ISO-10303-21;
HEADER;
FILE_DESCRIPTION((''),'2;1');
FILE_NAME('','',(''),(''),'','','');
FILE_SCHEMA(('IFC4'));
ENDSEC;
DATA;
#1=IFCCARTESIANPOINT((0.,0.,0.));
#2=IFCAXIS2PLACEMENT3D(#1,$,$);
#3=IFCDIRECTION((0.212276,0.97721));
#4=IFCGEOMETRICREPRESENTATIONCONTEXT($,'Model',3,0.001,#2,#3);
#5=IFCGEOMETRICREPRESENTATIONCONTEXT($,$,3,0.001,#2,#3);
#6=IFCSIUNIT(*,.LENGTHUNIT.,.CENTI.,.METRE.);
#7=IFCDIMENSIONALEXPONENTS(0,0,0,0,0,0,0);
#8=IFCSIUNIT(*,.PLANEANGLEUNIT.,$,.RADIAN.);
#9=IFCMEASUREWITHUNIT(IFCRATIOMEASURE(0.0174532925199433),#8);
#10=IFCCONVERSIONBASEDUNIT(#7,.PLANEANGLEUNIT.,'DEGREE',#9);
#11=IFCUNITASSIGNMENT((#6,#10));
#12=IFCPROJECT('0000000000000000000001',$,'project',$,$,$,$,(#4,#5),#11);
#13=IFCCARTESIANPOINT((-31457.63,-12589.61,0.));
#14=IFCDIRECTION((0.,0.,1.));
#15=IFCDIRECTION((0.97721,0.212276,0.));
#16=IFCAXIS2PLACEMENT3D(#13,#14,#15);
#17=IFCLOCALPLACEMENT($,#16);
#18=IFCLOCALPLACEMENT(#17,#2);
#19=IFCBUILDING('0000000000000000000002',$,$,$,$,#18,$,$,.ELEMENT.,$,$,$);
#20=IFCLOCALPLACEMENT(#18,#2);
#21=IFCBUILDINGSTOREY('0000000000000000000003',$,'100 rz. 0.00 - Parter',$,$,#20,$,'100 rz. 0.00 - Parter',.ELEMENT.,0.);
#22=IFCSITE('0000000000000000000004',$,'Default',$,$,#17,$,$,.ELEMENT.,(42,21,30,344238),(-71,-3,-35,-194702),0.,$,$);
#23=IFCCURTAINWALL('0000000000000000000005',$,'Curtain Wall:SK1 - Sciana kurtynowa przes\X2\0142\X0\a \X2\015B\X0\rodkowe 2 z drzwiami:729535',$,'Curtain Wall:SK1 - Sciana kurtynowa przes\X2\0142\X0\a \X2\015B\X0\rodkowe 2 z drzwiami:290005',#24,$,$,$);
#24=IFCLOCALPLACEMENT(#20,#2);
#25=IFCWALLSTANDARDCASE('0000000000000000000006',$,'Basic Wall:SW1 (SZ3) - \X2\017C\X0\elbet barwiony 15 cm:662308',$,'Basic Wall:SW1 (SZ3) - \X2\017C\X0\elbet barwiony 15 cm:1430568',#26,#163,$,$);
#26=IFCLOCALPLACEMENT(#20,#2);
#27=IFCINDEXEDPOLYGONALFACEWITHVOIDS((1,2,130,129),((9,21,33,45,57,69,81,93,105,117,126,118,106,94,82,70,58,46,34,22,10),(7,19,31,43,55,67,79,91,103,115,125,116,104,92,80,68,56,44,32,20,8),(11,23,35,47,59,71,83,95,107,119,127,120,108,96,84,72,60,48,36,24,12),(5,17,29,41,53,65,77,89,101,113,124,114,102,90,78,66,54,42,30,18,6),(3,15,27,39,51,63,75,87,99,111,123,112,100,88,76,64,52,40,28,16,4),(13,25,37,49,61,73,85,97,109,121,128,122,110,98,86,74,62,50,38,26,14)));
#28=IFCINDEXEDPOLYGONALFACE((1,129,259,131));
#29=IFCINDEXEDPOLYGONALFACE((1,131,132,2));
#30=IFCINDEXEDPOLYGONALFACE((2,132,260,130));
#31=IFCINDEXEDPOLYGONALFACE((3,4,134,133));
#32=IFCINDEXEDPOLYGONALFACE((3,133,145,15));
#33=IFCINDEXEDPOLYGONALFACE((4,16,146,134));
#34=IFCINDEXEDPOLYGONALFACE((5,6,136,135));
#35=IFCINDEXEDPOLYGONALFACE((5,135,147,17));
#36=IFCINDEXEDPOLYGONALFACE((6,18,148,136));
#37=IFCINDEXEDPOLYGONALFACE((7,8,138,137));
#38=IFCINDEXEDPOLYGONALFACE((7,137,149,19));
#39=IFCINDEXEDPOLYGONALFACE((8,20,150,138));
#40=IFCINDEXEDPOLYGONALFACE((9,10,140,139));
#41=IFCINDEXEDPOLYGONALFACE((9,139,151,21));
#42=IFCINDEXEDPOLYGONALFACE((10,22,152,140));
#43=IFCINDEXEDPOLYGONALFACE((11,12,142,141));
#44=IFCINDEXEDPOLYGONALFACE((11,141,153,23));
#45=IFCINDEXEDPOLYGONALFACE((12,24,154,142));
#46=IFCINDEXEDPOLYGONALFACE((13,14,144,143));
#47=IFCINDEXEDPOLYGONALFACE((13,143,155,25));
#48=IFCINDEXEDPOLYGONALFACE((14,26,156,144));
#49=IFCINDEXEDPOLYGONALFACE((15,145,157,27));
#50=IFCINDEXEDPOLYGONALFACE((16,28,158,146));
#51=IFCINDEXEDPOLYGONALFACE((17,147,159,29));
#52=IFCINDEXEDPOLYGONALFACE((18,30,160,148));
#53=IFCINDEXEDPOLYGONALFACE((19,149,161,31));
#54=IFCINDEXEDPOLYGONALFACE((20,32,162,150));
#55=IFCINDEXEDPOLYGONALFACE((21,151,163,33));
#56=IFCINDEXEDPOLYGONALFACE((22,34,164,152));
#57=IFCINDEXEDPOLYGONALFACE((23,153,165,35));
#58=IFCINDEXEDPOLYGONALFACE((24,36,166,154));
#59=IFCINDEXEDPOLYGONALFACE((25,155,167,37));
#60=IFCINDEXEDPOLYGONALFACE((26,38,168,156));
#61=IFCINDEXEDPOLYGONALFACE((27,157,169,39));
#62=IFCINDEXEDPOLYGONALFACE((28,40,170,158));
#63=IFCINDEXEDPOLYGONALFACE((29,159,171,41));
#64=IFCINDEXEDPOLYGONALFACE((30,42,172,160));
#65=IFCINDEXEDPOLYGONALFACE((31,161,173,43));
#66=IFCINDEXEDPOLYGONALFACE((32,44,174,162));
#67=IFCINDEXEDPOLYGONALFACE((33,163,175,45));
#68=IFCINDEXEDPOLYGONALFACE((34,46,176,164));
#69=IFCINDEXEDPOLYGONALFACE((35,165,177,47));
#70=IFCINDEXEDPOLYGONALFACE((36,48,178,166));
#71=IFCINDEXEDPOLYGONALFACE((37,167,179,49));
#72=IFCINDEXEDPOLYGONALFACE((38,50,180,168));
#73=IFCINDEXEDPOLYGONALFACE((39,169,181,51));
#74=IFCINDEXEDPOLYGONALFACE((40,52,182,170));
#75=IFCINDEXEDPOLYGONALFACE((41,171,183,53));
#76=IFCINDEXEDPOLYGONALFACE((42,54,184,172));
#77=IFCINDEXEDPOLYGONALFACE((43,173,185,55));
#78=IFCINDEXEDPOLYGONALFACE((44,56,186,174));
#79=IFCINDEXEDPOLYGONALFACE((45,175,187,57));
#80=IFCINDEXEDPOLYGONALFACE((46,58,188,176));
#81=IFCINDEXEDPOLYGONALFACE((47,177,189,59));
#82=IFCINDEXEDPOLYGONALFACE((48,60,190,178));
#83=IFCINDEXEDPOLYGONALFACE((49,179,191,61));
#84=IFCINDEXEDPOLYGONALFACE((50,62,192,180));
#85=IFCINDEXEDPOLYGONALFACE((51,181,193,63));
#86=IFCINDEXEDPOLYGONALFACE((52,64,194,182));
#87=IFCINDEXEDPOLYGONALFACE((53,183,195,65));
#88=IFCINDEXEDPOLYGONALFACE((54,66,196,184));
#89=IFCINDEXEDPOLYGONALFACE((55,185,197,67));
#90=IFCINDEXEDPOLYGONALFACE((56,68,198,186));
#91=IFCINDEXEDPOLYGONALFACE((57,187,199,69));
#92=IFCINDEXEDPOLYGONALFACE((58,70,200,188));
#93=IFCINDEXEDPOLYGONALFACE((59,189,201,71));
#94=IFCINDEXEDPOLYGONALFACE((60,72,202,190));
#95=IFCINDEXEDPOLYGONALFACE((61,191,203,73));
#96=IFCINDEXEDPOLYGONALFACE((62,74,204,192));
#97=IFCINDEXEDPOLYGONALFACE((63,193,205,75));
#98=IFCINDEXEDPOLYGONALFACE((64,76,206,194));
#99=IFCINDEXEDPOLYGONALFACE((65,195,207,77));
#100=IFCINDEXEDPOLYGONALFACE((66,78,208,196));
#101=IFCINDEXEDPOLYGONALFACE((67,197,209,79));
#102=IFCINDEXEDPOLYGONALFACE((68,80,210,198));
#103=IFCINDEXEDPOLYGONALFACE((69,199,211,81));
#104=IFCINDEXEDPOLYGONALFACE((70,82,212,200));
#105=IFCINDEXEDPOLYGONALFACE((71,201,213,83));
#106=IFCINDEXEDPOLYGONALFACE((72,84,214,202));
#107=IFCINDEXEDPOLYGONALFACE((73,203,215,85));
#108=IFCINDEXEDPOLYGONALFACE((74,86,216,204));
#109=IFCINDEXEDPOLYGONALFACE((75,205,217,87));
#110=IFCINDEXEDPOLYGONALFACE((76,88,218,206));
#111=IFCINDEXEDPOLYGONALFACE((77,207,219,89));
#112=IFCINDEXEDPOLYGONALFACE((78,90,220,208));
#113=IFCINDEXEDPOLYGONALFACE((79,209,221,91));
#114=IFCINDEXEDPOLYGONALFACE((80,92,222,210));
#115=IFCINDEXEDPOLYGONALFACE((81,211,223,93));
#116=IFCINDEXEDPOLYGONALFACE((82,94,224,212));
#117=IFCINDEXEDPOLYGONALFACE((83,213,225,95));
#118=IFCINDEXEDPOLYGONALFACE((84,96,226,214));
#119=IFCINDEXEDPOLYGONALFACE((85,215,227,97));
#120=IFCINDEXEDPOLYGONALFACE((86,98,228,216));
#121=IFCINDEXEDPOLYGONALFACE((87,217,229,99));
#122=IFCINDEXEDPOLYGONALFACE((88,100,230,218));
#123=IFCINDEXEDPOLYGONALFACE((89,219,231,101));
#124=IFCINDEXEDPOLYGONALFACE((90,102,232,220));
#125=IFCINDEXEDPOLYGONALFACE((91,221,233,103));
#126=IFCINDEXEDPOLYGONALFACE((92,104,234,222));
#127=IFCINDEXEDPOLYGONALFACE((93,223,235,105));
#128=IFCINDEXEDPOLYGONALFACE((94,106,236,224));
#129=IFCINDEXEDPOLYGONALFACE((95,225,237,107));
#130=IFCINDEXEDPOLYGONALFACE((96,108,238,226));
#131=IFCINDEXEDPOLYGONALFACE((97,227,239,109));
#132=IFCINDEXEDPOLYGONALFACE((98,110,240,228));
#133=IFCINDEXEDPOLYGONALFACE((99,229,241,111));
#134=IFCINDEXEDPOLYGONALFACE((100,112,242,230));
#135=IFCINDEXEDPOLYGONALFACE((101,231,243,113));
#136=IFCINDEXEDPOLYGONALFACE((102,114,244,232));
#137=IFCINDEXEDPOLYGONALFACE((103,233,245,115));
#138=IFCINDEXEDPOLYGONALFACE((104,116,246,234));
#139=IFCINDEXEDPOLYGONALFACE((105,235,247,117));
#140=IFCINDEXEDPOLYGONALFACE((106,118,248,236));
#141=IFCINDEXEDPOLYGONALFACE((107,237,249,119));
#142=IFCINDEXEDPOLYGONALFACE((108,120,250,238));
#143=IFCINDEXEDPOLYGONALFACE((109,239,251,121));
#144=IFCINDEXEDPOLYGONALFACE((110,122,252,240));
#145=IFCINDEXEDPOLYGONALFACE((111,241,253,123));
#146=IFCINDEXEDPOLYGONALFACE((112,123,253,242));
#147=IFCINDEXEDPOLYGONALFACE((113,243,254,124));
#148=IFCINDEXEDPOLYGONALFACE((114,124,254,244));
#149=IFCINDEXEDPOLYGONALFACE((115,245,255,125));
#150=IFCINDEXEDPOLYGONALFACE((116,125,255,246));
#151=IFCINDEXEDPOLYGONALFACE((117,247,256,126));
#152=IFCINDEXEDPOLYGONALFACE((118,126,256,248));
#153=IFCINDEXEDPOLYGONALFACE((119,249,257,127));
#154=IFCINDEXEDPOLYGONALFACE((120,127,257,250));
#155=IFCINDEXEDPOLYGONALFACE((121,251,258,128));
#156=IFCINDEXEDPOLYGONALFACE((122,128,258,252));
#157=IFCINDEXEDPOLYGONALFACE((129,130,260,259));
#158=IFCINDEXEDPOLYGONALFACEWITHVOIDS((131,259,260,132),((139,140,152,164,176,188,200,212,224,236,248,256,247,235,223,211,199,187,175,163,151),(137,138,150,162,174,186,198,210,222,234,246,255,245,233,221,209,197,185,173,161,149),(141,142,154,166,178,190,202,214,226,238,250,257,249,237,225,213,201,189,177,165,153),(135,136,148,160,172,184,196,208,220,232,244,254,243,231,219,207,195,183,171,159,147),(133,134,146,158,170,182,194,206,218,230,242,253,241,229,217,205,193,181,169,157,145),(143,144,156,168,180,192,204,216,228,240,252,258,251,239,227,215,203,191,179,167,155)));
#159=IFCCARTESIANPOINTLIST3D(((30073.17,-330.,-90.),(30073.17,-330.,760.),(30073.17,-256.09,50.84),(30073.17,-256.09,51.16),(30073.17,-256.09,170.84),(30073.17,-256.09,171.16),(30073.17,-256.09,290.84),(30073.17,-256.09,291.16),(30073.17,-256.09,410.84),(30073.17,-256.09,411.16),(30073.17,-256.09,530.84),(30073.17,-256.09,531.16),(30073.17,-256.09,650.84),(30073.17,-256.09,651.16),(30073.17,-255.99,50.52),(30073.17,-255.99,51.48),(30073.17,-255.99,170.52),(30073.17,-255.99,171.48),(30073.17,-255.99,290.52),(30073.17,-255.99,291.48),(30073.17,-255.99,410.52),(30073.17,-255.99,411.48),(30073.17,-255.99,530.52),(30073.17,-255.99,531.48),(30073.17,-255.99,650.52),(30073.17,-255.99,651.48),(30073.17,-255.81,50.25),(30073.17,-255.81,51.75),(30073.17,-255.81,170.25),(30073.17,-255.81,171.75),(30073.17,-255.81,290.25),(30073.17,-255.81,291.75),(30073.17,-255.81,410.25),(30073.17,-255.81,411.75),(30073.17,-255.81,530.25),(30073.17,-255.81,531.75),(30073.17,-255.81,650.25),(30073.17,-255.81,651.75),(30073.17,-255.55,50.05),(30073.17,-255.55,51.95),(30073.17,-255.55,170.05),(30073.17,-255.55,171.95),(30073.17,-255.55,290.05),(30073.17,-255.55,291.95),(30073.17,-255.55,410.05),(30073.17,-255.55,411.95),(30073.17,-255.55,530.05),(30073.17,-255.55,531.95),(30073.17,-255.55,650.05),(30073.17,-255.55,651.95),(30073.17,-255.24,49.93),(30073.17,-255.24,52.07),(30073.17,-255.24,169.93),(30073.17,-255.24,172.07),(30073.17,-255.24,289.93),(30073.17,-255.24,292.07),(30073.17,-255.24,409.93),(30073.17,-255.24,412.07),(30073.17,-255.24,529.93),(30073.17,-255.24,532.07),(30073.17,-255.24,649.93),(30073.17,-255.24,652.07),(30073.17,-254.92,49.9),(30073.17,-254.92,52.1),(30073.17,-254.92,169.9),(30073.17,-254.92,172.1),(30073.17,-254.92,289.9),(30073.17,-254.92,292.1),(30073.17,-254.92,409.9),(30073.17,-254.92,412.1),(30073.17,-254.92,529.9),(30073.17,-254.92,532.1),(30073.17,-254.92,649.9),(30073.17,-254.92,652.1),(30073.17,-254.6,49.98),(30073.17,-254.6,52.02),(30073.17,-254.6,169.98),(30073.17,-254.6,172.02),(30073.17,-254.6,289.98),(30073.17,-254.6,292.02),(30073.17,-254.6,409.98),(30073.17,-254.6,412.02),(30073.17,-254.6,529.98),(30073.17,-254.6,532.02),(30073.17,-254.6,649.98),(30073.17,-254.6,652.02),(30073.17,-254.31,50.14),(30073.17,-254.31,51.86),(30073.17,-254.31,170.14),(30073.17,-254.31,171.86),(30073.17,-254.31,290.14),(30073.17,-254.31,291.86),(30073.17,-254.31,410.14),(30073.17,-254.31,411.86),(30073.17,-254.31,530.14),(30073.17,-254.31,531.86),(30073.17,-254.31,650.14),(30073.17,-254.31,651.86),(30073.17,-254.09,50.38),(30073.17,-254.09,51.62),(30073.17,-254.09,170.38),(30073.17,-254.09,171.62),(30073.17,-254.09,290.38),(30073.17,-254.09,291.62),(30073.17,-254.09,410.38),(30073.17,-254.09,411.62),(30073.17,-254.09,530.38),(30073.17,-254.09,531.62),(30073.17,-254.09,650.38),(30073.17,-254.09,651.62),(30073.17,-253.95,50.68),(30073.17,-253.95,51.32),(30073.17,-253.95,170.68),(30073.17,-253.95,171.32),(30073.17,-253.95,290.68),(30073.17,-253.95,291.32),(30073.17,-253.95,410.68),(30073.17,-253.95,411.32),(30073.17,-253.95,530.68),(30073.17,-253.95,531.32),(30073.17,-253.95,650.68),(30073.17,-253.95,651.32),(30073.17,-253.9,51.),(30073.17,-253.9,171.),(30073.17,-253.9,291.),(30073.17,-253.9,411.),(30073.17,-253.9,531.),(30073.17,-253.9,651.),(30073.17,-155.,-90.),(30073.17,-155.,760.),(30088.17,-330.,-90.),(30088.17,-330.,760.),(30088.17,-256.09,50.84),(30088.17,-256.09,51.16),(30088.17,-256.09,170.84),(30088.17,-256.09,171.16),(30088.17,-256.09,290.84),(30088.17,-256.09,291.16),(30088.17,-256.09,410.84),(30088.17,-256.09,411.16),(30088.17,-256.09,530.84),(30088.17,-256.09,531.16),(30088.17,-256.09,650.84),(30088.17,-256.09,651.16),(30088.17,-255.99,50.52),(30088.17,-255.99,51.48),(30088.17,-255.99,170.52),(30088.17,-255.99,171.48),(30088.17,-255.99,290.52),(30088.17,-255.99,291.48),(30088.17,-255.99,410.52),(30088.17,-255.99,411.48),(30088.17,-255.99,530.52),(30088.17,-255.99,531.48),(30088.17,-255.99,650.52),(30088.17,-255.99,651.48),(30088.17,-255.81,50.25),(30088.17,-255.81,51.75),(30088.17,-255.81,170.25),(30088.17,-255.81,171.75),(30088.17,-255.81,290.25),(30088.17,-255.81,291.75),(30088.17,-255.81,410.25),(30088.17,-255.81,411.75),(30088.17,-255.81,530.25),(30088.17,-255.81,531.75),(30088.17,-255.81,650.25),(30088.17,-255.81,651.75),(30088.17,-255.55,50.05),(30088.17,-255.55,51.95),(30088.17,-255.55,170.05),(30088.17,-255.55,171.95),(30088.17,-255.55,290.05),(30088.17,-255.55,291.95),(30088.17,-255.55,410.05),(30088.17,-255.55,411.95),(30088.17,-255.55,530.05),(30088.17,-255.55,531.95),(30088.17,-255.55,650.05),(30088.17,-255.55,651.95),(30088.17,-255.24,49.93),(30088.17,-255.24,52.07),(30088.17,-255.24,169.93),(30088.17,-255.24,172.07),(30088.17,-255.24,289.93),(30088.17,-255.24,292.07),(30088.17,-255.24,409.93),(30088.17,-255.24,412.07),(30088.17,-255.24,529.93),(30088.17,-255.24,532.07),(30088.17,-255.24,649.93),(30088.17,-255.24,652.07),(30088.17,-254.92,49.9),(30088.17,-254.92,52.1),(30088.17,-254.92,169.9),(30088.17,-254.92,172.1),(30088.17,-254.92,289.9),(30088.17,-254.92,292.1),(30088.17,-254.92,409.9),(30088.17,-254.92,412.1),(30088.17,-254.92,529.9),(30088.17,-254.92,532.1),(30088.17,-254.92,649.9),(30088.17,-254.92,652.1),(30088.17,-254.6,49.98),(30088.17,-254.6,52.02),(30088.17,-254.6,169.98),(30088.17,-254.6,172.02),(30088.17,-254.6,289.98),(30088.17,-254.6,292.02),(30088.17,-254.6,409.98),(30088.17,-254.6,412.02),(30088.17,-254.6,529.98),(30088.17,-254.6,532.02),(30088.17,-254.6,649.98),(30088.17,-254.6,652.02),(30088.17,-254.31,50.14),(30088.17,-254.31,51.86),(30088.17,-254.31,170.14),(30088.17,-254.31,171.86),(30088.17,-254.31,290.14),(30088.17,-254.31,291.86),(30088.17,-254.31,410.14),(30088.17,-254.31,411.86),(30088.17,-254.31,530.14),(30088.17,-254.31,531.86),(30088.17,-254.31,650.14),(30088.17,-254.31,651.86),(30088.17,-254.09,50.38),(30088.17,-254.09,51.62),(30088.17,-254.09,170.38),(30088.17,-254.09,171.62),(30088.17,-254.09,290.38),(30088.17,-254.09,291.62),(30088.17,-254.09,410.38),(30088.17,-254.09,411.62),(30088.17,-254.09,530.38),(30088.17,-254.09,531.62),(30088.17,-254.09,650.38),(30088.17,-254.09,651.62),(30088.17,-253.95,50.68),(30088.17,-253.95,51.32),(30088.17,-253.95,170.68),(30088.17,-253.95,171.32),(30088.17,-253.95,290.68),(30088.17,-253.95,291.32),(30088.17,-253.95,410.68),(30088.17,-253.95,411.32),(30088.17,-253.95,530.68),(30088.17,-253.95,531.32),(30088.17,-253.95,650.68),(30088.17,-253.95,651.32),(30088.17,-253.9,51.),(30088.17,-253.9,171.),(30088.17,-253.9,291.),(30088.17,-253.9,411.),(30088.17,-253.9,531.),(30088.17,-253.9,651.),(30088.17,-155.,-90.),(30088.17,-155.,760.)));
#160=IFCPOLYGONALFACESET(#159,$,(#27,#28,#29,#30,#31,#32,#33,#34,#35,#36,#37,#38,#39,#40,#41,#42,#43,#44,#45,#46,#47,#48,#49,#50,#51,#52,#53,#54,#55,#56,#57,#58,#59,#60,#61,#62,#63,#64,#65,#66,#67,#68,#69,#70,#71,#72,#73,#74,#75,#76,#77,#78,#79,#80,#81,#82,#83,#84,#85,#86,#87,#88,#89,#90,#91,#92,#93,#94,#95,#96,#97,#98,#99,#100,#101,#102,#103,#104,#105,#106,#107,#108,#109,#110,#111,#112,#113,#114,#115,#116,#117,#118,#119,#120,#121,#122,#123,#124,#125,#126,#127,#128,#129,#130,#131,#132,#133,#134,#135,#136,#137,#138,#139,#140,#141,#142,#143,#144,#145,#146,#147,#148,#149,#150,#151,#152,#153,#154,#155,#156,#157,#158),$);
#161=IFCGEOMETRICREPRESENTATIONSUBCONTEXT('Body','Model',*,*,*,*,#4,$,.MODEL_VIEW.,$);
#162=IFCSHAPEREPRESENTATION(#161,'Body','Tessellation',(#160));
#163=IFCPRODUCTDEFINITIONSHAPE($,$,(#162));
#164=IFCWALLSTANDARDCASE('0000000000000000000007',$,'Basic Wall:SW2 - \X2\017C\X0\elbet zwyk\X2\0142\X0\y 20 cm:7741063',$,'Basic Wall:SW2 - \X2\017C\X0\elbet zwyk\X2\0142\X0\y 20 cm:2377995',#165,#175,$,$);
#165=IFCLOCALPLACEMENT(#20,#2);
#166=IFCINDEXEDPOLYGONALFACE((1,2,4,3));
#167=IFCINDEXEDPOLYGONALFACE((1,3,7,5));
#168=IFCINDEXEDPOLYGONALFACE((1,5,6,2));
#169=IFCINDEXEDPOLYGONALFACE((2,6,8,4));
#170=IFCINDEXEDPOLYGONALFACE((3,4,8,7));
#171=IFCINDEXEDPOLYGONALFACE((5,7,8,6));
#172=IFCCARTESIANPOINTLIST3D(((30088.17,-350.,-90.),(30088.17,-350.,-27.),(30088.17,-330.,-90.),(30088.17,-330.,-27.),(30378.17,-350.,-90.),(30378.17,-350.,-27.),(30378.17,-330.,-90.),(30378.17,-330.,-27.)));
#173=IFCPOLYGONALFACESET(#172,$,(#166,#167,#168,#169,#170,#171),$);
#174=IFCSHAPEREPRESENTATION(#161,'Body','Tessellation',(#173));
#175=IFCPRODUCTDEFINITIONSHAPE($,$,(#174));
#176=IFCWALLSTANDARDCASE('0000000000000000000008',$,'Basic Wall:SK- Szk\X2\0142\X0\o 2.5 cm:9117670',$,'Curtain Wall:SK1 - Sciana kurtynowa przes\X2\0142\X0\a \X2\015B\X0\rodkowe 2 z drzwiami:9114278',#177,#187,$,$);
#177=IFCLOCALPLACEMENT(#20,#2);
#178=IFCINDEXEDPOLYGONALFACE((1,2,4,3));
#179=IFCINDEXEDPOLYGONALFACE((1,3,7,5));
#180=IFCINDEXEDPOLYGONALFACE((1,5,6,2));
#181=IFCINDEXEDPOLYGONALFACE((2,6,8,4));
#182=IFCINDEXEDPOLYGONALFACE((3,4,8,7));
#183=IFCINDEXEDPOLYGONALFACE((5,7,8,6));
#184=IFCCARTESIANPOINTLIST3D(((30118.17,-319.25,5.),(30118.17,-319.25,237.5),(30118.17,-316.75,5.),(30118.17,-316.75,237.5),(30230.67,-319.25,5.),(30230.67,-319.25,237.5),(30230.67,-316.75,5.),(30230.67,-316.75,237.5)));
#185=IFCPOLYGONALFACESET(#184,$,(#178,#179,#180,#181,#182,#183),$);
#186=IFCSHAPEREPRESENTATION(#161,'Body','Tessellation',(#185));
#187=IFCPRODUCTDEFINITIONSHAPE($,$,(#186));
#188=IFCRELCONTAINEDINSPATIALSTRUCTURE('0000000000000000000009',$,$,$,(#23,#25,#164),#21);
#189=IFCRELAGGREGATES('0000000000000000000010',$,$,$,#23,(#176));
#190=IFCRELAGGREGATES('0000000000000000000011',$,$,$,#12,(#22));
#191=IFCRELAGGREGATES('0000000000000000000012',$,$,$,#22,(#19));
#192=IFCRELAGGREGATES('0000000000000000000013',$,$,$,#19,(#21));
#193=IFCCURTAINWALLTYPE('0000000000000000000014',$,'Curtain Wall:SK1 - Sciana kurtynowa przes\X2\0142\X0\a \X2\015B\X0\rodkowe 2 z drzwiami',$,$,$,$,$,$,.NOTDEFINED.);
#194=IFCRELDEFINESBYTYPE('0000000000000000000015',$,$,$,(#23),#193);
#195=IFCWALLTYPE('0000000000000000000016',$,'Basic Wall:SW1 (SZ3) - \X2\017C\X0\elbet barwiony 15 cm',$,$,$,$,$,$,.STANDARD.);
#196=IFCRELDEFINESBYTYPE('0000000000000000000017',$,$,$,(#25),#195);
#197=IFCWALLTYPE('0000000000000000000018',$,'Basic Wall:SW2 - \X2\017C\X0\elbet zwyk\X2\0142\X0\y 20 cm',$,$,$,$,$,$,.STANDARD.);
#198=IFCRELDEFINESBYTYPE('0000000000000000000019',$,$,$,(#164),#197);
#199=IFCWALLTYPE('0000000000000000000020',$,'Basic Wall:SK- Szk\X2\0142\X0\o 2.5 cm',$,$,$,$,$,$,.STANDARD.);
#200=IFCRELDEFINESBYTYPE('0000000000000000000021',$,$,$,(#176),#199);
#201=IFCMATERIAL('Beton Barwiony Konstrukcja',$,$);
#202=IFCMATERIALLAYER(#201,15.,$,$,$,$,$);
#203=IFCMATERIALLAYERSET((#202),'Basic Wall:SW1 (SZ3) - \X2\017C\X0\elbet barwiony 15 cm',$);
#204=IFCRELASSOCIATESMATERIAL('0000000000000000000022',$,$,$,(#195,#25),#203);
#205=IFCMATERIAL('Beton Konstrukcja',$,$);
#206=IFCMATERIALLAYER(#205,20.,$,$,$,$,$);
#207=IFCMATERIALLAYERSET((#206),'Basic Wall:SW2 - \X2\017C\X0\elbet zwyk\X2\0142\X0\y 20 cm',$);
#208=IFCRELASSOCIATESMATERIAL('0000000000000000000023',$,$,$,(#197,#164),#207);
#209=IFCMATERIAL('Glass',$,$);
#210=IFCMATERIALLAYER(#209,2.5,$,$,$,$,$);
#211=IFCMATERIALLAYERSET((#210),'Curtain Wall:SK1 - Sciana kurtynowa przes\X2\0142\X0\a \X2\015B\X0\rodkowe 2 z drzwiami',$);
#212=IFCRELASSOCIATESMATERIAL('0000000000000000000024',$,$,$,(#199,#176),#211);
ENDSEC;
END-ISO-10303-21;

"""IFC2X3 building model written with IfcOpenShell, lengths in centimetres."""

from ifc_helpers import new_model, entity, si_unit, converted_unit, direction, frame, frame_2d, origin, origin_2d_with_axis, place, context, subcontext, project, spatial, rectangle, circle, extrude, material, layer, layer_set, layer_usage, type_object, element, aggregate, save


model = new_model("IFC2X3")

# Units and contexts
model_context = context("Model", 3, precision=0.001, world=origin(), true_north=direction((0.212276, 0.97721)))
context_of_model = context(None, 3, precision=0.001, world=origin(), true_north=direction((0.212276, 0.97721)))
body_context = subcontext(model_context, "Body", "Model", "MODEL_VIEW")
ifc_project = project(units=[si_unit("LENGTHUNIT", "METRE", prefix="CENTI"), converted_unit("PLANEANGLEUNIT", "DEGREE", entity("IfcRatioMeasure", 0.0174532925199433), si_unit("PLANEANGLEUNIT", "RADIAN"), dimensions=[0, 0, 0, 0, 0, 0, 0])], contexts=[model_context, context_of_model])

# Site, building, storey
site_placement = place(None, frame((-31457.63, -12589.61, 0.0), z_axis=(0.0, 0.0, 1.0), x_axis=(0.97721, 0.212276, 0.0)))
site = spatial("IfcSite", under=ifc_project, at=site_placement, Name="Default", CompositionType="ELEMENT", RefLatitude=(42, 21, 30, 344238), RefLongitude=(-71, -3, -35, -194702), RefElevation=0.0)
building_placement = place(site_placement, origin())
building = spatial("IfcBuilding", under=site, at=building_placement, CompositionType="ELEMENT")
storey_placement = place(building_placement, origin())
storey = spatial("IfcBuildingStorey", under=building, at=storey_placement, Name="100 rz. 0.00 - Parter", LongName="100 rz. 0.00 - Parter", CompositionType="ELEMENT", Elevation=0.0)

# Curtain wall
curtain_wall_type = type_object("IfcCurtainWallType", Name="Curtain Wall:SK1 - Sciana kurtynowa przesła środkowe 2 z drzwiami", PredefinedType="NOTDEFINED")
curtain_wall_placement = place(storey_placement, origin())
curtain_wall = element("IfcCurtainWall", 1, at=curtain_wall_placement, inside=storey, type_object=curtain_wall_type, Name="Curtain Wall:SK1 - Sciana kurtynowa przesła środkowe 2 z drzwiami:729535", ObjectType="Curtain Wall:SK1 - Sciana kurtynowa przesła środkowe 2 z drzwiami:290005")

# Wall, opening
ifc_material_1 = material(Name="Beton Barwiony Konstrukcja")
ifc_layer_1 = layer(ifc_material_1, 15.0)
ifc_layer_set_1 = layer_set([ifc_layer_1], Name="Basic Wall:SW1 (SZ3) - żelbet barwiony 15 cm")
ifc_layer_usage_1 = layer_usage(ifc_layer_set_1, "AXIS2", "NEGATIVE", 7.5)
wall_type_1 = type_object("IfcWallType", Name="Basic Wall:SW1 (SZ3) - żelbet barwiony 15 cm", PredefinedType="STANDARD", material=ifc_layer_set_1)
wall_1_placement = place(storey_placement, frame((30080.67, -330.0, -90.0), z_axis=(0.0, 0.0, 1.0), x_axis=(0.0, 1.0, 0.0)))
wall_1 = element("IfcWallStandardCase", 2, at=wall_1_placement, inside=storey, type_object=wall_type_1, material=ifc_layer_usage_1, Name="Basic Wall:SW1 (SZ3) - żelbet barwiony 15 cm:662308", ObjectType="Basic Wall:SW1 (SZ3) - żelbet barwiony 15 cm:1430568", context=body_context, shape_type="SweptSolid", body=[
    extrude(rectangle(XDim=175.0, YDim=15.0, at=frame_2d((87.5, 0.0), x_axis=(-1.0, 0.0))), origin(), (0.0, 0.0, 1.0), 850.0),
])
opening_placement = place(wall_1_placement, frame((73.74, 7.5, 139.74)))
element("IfcOpeningElement", 3, at=opening_placement, cuts=wall_1, ObjectType="Opening", context=body_context, shape_type="SweptSolid", body=[
    extrude(circle(Radius=1.1, at=frame_2d((0.0, 0.0), x_axis=(1.0, 0.0))), frame((1.26, -15.0, 1.26), z_axis=(0.0, 1.0, 0.0), x_axis=(1.0, 0.0, 0.0)), (0.0, 0.0, 1.0), 15.0),
    extrude(circle(Radius=1.1, at=origin_2d_with_axis()), frame((1.26, -15.0, 601.26), z_axis=(0.0, 1.0, 0.0), x_axis=(1.0, 0.0, 0.0)), (0.0, 0.0, 1.0), 15.0),
    extrude(circle(Radius=1.1, at=origin_2d_with_axis()), frame((1.26, -15.0, 121.26), z_axis=(0.0, 1.0, 0.0), x_axis=(1.0, 0.0, 0.0)), (0.0, 0.0, 1.0), 15.0),
    extrude(circle(Radius=1.1, at=origin_2d_with_axis()), frame((1.26, -15.0, 241.26), z_axis=(0.0, 1.0, 0.0), x_axis=(1.0, 0.0, 0.0)), (0.0, 0.0, 1.0), 15.0),
    extrude(circle(Radius=1.1, at=origin_2d_with_axis()), frame((1.26, -15.0, 361.26), z_axis=(0.0, 1.0, 0.0), x_axis=(1.0, 0.0, 0.0)), (0.0, 0.0, 1.0), 15.0),
    extrude(circle(Radius=1.1, at=origin_2d_with_axis()), frame((1.26, -15.0, 481.26), z_axis=(0.0, 1.0, 0.0), x_axis=(1.0, 0.0, 0.0)), (0.0, 0.0, 1.0), 15.0),
])

# Walls
ifc_material_2 = material(Name="Beton Konstrukcja")
ifc_layer_2 = layer(ifc_material_2, 20.0)
ifc_layer_set_2 = layer_set([ifc_layer_2], Name="Basic Wall:SW2 - żelbet zwykły 20 cm")
ifc_layer_usage_2 = layer_usage(ifc_layer_set_2, "AXIS2", "NEGATIVE", 10.0)
wall_type_2 = type_object("IfcWallType", Name="Basic Wall:SW2 - żelbet zwykły 20 cm", PredefinedType="STANDARD", material=ifc_layer_set_2)
wall_2_placement = place(storey_placement, frame((30088.17, -340.0, -90.0)))
element("IfcWallStandardCase", 4, at=wall_2_placement, inside=storey, type_object=wall_type_2, material=ifc_layer_usage_2, Name="Basic Wall:SW2 - żelbet zwykły 20 cm:7741063", ObjectType="Basic Wall:SW2 - żelbet zwykły 20 cm:2377995", context=body_context, shape_type="SweptSolid", body=[
    extrude(rectangle(XDim=290.0, YDim=20.0, at=frame_2d((145.0, 0.0), x_axis=(-1.0, 0.0))), origin(), (0.0, 0.0, 1.0), 63.0),
])
ifc_material_3 = material(Name="Glass")
ifc_layer_3 = layer(ifc_material_3, 2.5)
ifc_layer_set_3 = layer_set([ifc_layer_3], Name="Curtain Wall:SK1 - Sciana kurtynowa przesła środkowe 2 z drzwiami")
ifc_layer_usage_3 = layer_usage(ifc_layer_set_3, "AXIS2", "NEGATIVE", 1.25)
wall_type_3 = type_object("IfcWallType", Name="Basic Wall:SK- Szkło 2.5 cm", PredefinedType="STANDARD", material=ifc_layer_set_3)
wall_3_placement = place(storey_placement, frame((30118.17, -318.0, 5.0)))
wall_3 = element("IfcWallStandardCase", 5, at=wall_3_placement, type_object=wall_type_3, material=ifc_layer_usage_3, Name="Basic Wall:SK- Szkło 2.5 cm:9117670", ObjectType="Curtain Wall:SK1 - Sciana kurtynowa przesła środkowe 2 z drzwiami:9114278", context=body_context, shape_type="SweptSolid", body=[
    extrude(rectangle(XDim=112.5, YDim=2.5, at=frame_2d((56.25, 0.0), x_axis=(-1.0, 0.0))), origin(), (0.0, 0.0, 1.0), 232.5),
])
aggregate(curtain_wall, [wall_3])

save(model, "model.ifc")
